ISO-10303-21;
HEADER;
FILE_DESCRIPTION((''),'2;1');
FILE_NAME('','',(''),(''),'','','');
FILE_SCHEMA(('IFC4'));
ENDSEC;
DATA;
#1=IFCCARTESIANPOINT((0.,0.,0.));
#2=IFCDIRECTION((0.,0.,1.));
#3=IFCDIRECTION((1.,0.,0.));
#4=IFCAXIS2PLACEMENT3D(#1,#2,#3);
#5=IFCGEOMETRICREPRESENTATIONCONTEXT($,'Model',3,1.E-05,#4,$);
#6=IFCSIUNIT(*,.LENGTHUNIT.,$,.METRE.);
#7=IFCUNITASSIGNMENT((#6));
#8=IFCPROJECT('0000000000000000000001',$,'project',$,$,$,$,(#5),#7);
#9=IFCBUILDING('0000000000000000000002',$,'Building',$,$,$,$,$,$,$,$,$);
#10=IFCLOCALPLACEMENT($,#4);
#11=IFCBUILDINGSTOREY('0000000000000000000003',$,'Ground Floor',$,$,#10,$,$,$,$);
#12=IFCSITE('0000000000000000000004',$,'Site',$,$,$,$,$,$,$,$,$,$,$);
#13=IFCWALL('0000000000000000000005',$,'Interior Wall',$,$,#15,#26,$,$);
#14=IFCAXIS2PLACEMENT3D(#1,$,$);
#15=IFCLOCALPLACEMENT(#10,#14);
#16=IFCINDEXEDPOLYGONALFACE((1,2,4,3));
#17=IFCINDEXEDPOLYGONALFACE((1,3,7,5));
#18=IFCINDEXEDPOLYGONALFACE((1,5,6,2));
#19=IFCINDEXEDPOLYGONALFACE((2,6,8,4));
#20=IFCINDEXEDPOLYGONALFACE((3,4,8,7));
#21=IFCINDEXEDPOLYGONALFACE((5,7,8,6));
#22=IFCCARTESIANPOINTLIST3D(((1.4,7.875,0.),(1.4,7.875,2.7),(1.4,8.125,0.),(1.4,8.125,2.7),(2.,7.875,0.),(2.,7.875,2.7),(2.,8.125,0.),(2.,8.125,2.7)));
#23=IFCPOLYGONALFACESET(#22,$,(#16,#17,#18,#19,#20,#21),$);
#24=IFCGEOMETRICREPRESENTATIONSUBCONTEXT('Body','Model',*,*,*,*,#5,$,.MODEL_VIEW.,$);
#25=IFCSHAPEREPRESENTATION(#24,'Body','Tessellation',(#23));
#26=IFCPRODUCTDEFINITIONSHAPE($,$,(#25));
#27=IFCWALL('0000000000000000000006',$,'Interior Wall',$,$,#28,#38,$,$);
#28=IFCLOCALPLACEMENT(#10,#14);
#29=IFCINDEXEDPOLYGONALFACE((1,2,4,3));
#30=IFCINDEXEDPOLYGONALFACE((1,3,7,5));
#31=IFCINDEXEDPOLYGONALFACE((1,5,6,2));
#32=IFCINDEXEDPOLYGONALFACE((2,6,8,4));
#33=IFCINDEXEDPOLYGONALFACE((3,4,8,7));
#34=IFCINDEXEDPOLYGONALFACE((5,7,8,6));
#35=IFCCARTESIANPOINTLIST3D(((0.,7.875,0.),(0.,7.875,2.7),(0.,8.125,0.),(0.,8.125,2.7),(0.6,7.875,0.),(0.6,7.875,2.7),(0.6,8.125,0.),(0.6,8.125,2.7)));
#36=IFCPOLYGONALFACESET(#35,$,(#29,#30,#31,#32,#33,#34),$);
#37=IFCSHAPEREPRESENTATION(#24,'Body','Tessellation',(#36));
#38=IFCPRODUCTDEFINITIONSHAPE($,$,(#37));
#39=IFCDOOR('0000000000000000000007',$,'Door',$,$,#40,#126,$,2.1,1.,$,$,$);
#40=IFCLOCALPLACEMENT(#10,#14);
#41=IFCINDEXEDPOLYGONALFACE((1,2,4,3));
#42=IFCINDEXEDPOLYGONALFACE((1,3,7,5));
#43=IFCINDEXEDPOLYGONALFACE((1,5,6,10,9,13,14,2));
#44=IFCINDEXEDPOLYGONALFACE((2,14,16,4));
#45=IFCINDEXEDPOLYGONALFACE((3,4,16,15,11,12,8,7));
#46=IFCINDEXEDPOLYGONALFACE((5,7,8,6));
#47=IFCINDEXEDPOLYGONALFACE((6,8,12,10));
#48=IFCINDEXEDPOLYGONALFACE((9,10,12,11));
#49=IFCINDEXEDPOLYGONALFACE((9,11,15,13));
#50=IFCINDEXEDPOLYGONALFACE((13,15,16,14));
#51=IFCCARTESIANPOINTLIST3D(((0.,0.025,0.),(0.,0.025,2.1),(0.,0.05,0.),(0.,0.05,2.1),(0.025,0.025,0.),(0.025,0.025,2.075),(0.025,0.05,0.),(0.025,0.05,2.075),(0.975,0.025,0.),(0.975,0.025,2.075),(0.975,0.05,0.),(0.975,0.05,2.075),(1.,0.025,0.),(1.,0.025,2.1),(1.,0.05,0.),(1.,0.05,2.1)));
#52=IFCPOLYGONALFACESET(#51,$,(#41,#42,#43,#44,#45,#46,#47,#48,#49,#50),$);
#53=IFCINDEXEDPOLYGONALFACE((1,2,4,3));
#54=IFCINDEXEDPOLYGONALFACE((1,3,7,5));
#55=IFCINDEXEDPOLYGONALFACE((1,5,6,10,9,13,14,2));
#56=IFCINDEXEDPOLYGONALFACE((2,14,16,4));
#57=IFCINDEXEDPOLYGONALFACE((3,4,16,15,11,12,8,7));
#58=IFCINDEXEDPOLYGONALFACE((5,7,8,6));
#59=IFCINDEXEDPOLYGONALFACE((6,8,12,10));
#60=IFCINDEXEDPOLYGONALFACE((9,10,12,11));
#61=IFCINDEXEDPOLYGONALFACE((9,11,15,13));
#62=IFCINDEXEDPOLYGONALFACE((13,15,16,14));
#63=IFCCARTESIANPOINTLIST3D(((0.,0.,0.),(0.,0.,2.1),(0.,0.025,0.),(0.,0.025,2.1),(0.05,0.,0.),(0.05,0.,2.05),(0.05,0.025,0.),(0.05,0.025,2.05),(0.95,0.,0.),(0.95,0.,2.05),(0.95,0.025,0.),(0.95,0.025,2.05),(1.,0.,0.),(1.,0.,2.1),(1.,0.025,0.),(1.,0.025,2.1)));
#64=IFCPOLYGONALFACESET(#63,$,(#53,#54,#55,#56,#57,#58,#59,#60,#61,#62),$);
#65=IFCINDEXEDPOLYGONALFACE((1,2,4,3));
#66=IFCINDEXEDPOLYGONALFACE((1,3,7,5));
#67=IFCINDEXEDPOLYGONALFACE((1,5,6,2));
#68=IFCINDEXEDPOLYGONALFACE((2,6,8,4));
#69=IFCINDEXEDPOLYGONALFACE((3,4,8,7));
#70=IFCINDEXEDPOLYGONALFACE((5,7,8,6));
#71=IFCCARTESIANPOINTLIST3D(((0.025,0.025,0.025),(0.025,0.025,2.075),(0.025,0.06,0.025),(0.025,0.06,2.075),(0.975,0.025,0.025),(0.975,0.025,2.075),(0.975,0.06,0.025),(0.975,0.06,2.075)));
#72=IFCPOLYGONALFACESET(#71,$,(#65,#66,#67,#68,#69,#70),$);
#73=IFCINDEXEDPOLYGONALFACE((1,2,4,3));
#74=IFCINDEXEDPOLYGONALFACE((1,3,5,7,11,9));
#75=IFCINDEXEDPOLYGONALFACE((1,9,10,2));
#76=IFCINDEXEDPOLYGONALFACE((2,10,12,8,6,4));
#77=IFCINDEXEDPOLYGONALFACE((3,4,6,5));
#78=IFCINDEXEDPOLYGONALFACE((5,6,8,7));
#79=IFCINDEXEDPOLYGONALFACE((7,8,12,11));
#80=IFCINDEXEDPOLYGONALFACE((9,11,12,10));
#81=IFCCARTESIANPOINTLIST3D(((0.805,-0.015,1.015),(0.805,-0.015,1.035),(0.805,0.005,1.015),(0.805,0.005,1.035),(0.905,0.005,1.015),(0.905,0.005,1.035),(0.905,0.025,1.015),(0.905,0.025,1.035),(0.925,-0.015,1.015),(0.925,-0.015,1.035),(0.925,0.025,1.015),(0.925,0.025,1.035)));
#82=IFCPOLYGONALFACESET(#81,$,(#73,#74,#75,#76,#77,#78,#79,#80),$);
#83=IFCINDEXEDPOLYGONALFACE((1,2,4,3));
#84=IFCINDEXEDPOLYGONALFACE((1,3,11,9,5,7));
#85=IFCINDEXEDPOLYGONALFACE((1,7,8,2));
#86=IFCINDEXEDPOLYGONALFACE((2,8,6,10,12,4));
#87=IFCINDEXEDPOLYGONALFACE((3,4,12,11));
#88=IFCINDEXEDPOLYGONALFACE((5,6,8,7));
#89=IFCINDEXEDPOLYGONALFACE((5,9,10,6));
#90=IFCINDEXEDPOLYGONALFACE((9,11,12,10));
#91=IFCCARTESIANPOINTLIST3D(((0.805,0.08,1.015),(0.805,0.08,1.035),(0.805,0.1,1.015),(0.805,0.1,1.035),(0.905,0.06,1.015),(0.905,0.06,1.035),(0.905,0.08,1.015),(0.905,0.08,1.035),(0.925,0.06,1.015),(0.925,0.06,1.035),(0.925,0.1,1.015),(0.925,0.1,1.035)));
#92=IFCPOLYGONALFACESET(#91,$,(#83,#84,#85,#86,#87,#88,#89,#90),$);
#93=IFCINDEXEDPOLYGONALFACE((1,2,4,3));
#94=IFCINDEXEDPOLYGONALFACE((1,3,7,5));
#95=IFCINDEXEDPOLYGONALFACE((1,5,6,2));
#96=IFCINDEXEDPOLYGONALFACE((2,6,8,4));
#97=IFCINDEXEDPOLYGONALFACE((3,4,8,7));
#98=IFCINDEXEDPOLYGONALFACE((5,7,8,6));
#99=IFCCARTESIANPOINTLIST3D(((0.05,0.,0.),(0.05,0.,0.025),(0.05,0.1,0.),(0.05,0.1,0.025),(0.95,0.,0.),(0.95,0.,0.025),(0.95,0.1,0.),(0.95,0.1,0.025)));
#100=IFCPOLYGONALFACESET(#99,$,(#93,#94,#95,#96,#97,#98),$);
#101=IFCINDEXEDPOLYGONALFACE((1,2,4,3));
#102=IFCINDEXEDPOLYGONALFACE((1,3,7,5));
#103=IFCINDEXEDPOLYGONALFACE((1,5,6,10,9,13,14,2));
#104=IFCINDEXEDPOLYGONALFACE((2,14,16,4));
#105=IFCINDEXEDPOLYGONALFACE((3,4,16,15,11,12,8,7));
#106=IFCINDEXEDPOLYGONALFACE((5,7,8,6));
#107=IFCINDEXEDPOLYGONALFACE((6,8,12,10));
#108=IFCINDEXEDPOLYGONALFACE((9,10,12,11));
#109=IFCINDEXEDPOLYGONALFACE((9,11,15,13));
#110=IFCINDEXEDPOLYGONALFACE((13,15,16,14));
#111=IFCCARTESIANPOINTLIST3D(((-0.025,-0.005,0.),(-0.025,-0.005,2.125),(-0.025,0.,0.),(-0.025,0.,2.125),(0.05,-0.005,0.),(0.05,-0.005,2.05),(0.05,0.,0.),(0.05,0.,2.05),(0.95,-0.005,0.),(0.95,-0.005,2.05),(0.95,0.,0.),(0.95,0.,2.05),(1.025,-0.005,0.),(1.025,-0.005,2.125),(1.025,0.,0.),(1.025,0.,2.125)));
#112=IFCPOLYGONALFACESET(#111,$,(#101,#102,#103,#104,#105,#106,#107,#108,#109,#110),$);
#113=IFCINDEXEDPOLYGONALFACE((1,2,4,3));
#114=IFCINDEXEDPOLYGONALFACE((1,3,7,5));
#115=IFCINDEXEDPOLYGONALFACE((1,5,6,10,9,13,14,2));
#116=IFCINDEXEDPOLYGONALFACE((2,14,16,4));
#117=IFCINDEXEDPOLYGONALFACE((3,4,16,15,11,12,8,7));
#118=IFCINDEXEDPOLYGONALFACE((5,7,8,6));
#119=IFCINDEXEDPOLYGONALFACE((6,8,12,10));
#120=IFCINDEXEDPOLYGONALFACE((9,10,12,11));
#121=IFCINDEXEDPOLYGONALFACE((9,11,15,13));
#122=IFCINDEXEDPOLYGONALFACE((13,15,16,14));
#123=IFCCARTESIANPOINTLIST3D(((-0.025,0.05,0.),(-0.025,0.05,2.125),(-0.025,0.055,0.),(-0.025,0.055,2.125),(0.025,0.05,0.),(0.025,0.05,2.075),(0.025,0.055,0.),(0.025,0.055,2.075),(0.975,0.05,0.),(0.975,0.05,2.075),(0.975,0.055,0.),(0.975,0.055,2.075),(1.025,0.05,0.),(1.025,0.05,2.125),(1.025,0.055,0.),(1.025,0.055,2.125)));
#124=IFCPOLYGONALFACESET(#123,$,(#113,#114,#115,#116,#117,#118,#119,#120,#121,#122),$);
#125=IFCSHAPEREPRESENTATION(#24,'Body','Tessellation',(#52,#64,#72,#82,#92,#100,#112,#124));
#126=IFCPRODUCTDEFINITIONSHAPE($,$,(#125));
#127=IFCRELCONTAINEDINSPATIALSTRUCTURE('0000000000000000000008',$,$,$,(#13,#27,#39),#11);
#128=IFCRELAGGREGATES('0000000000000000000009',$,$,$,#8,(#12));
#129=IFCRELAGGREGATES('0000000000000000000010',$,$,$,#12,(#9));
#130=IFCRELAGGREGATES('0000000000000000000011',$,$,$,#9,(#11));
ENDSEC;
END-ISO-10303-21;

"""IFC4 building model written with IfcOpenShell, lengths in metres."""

from ifc_helpers import new_model, si_unit, frame, origin_with_axes, place, context, subcontext, project, spatial, line, indexed_curve, outline, extrude, element, save


model = new_model("IFC4")

# Units and contexts
model_context = context("Model", 3, precision=1e-05, world=origin_with_axes())
body_context = subcontext(model_context, "Body", "Model", "MODEL_VIEW")
ifc_project = project(units=[si_unit("LENGTHUNIT", "METRE")], contexts=[model_context])

# Site, building, storey
site = spatial("IfcSite", under=ifc_project, Name="Site")
building = spatial("IfcBuilding", under=site, Name="Building")
storey_placement = place(None, origin_with_axes())
storey = spatial("IfcBuildingStorey", under=building, at=storey_placement, Name="Ground Floor")

# Walls
for number, where, z_axis, x_axis, name in (
    (1, (2.0, 8.0, 0.0), (0.0, 0.0, 1.0), (-1.0, 0.0, 0.0), "Interior Wall"),
    (2, (0.6, 8.0, 0.0), (0.0, 0.0, 1.0), (-1.0, 0.0, 0.0), "Interior Wall"),
):
    element("IfcWall", number, at=place(storey_placement, frame(where, z_axis=z_axis, x_axis=x_axis)), inside=storey, Name=name, context=body_context, shape_type="SweptSolid", body=[
        extrude(outline(indexed_curve([(0.0, 0.0), (0.0, 0.25), (0.6, 0.25), (0.6, 0.0), (0.0, 0.0)], self_intersect=False)), frame((0.0, -0.125, 0.0), z_axis=(0.0, 0.0, 1.0), x_axis=(1.0, 0.0, 0.0)), (0.0, 0.0, 1.0), 2.7),
    ])

# Door
door_1_placement = place(storey_placement, origin_with_axes())
element("IfcDoor", 3, at=door_1_placement, inside=storey, Name="Door", OverallHeight=2.1, OverallWidth=1.0, context=body_context, shape_type="SweptSolid", body=[
    extrude(outline(indexed_curve([(0.0, 0.0), (0.0, 2.1), (1.0, 2.1), (1.0, 0.0), (0.975, 0.0), (0.975, 2.075), (0.025, 2.075), (0.025, 0.0)], segments=[line(1, 2, 3, 4, 5, 6, 7, 8, 1)])), frame((0.0, 0.025, 0.0), z_axis=(0.0, -1.0, 0.0), x_axis=(1.0, 0.0, 0.0)), (0.0, 0.0, -1.0), 0.025),
    extrude(outline(indexed_curve([(0.0, 0.0), (0.0, 2.1), (1.0, 2.1), (1.0, 0.0), (0.95, 0.0), (0.95, 2.05), (0.05, 2.05), (0.05, 0.0)], segments=[line(1, 2, 3, 4, 5, 6, 7, 8, 1)])), frame((0.0, 0.0, 0.0), z_axis=(0.0, -1.0, 0.0), x_axis=(1.0, 0.0, 0.0)), (0.0, 0.0, -1.0), 0.025),
    extrude(outline(indexed_curve([(0.0, 0.0), (0.95, 0.0), (0.95, 0.035), (0.0, 0.035)], segments=[line(1, 2, 3, 4, 1)])), frame((0.025, 0.025, 0.025), z_axis=(0.0, 0.0, 1.0), x_axis=(1.0, 0.0, 0.0)), (0.0, 0.0, 1.0), 2.05),
    extrude(outline(indexed_curve([(0.0, 0.0), (0.0, -0.04), (-0.12, -0.04), (-0.12, -0.02), (-0.02, -0.02), (-0.02, 0.0)], segments=[line(1, 2, 3, 4, 5, 6, 1)])), frame((0.925, 0.025, 1.015), z_axis=(0.0, 0.0, 1.0), x_axis=(1.0, 0.0, 0.0)), (0.0, 0.0, 1.0), 0.02),
    extrude(outline(indexed_curve([(0.0, 0.0), (0.0, 0.04), (-0.12, 0.04), (-0.12, 0.02), (-0.02, 0.02), (-0.02, 0.0)], segments=[line(1, 2, 3, 4, 5, 6, 1)])), frame((0.925, 0.06, 1.015), z_axis=(0.0, 0.0, 1.0), x_axis=(1.0, 0.0, 0.0)), (0.0, 0.0, 1.0), 0.02),
    extrude(outline(indexed_curve([(0.0, 0.0), (0.9, 0.0), (0.9, 0.1), (0.0, 0.1)], segments=[line(1, 2, 3, 4, 1)])), frame((0.05, 0.0, 0.0), z_axis=(0.0, 0.0, 1.0), x_axis=(1.0, 0.0, 0.0)), (0.0, 0.0, 1.0), 0.025),
    extrude(outline(indexed_curve([(0.0, 0.0), (0.0, 2.125), (1.05, 2.125), (1.05, 0.0), (0.975, 0.0), (0.975, 2.05), (0.075, 2.05), (0.075, 0.0)], segments=[line(1, 2, 3, 4, 5, 6, 7, 8, 1)])), frame((-0.025, -0.005, 0.0), z_axis=(0.0, -1.0, 0.0), x_axis=(1.0, 0.0, 0.0)), (0.0, 0.0, -1.0), 0.005),
    extrude(outline(indexed_curve([(0.0, 0.0), (0.0, 2.125), (1.05, 2.125), (1.05, 0.0), (1.0, 0.0), (1.0, 2.075), (0.05, 2.075), (0.05, 0.0)], segments=[line(1, 2, 3, 4, 5, 6, 7, 8, 1)])), frame((-0.025, 0.05, 0.0), z_axis=(0.0, -1.0, 0.0), x_axis=(1.0, 0.0, 0.0)), (0.0, 0.0, -1.0), 0.005),
])

save(model, "model.ifc")
